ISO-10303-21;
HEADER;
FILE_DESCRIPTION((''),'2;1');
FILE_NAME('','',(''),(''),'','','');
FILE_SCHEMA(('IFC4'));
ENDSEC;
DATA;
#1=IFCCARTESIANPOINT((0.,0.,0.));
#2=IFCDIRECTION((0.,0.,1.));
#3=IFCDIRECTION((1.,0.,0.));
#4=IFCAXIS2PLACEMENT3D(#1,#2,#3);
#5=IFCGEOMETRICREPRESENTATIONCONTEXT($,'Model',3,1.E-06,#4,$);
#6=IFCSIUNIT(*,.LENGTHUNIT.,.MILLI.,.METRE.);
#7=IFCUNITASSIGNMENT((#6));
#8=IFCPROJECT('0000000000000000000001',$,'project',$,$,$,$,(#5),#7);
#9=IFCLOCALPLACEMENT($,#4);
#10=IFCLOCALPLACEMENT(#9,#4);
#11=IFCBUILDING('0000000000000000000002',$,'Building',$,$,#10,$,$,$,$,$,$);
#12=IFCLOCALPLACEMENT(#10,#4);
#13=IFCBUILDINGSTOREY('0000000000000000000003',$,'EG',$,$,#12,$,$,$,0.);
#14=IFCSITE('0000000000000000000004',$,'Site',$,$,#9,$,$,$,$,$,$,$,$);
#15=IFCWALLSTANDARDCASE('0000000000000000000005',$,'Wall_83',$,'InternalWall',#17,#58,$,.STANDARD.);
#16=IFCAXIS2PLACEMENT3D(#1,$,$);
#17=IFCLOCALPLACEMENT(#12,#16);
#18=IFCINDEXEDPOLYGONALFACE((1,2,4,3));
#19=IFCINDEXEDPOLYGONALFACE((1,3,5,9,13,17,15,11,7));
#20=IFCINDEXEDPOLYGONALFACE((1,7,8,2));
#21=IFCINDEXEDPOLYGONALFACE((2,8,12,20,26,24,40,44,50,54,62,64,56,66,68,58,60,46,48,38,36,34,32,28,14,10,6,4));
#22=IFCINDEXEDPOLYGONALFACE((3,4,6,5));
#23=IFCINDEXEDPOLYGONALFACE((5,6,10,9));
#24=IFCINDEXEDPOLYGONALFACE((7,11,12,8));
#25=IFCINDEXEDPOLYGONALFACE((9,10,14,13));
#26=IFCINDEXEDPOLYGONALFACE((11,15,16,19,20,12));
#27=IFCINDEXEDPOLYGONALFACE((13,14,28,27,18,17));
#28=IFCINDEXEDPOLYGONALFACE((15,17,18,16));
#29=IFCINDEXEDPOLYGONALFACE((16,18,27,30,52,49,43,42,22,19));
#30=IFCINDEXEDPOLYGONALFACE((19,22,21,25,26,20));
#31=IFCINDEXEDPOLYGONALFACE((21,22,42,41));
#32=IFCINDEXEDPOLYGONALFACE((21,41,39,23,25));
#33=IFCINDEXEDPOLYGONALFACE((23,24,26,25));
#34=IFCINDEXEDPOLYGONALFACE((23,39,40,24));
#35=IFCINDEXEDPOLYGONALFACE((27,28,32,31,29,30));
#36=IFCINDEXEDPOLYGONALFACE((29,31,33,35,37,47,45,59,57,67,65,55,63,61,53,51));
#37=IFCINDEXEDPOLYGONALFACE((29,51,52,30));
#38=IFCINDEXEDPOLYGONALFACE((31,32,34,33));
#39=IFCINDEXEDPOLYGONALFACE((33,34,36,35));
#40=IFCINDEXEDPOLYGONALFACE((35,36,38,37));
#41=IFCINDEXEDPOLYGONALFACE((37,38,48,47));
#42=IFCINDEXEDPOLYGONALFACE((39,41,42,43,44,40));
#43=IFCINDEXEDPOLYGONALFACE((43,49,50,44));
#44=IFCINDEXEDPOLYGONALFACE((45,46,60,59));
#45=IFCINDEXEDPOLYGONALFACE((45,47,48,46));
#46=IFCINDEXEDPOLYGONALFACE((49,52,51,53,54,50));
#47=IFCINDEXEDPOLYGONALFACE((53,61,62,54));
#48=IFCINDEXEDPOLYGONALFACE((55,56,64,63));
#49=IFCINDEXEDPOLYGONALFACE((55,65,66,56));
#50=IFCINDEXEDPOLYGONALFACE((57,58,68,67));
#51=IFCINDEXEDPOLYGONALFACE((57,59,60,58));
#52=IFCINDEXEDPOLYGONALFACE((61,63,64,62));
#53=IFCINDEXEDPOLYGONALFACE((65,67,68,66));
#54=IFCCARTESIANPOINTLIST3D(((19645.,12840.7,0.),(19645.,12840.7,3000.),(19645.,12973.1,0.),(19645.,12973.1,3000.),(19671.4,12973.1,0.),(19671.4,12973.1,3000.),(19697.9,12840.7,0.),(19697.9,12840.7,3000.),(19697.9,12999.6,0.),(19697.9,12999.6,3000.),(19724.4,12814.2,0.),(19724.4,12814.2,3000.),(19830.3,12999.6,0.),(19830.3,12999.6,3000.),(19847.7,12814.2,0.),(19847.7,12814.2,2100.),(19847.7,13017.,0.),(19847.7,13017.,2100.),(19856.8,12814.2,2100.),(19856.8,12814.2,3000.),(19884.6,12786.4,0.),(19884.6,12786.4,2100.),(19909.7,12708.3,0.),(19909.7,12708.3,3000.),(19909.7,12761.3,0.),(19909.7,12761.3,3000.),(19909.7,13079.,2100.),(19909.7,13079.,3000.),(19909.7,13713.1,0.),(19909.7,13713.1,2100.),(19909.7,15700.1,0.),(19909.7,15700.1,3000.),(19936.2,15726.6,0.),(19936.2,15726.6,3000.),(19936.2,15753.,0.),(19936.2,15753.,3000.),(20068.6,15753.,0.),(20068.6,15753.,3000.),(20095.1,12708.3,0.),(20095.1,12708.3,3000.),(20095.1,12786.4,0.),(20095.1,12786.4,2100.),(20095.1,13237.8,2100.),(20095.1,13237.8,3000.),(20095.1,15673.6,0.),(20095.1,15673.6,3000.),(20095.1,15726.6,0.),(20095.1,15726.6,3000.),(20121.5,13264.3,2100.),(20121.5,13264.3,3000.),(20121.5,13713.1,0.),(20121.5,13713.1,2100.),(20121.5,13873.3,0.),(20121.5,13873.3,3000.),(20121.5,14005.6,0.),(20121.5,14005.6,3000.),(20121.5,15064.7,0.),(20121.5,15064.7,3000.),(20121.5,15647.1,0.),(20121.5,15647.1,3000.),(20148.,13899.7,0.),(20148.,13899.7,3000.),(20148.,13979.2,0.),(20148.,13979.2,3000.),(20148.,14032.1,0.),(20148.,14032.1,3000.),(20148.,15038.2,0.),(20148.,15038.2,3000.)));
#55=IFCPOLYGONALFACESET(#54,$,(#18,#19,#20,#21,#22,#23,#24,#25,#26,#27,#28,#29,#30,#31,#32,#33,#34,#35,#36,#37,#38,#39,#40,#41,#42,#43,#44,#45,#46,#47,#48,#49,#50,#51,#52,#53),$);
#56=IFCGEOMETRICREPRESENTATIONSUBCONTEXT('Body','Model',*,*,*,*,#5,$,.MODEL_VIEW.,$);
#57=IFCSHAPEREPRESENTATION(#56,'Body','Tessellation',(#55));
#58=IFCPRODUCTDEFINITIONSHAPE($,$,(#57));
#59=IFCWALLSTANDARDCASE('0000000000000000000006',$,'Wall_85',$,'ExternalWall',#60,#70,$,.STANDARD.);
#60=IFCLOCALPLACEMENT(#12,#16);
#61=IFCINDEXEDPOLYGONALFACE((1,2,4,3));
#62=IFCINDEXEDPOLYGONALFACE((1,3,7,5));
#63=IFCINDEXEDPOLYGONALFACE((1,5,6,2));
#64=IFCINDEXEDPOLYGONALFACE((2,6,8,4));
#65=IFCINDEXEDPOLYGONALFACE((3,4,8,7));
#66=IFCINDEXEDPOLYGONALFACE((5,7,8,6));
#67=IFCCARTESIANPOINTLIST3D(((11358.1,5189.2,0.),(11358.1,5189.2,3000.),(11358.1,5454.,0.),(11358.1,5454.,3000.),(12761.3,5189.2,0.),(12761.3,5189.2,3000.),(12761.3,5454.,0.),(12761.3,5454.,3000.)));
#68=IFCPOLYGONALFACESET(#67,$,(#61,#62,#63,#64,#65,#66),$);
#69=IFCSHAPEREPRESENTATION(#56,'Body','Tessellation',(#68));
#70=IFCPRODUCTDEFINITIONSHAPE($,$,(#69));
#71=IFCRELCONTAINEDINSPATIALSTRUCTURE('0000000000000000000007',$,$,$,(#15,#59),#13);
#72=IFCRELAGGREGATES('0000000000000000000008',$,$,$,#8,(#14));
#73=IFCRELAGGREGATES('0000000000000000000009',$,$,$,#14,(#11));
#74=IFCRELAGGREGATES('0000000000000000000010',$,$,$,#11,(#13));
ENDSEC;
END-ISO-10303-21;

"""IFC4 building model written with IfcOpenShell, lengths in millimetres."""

from ifc_helpers import new_model, si_unit, frame, origin_with_axes, place, context, subcontext, project, spatial, polyline, rectangle, outline, extrude, element, save


model = new_model("IFC4")

# Units and contexts
model_context = context("Model", 3, precision=1e-06, world=origin_with_axes())
body_context = subcontext(model_context, "Body", "Model", "MODEL_VIEW")
ifc_project = project(units=[si_unit("LENGTHUNIT", "METRE", prefix="MILLI")], contexts=[model_context])

# Site, building, storey
site_placement = place(None, origin_with_axes())
site = spatial("IfcSite", under=ifc_project, at=site_placement, Name="Site")
building_placement = place(site_placement, origin_with_axes())
building = spatial("IfcBuilding", under=site, at=building_placement, Name="Building")
storey_placement = place(building_placement, origin_with_axes())
storey = spatial("IfcBuildingStorey", under=building, at=storey_placement, Name="EG", Elevation=0.0)

# Wall, opening
wall_1_placement = place(storey_placement, origin_with_axes())
wall_1 = element("IfcWallStandardCase", 1, at=wall_1_placement, inside=storey, Name="Wall_83", ObjectType="InternalWall", PredefinedType="STANDARD", context=body_context, shape_type="SweptSolid", body=[
    extrude(outline(polyline([(19909.7, 12708.3, 0.0), (19909.7, 12761.3, 0.0), (19856.8, 12814.2, 0.0), (19724.4, 12814.2, 0.0), (19697.9, 12840.7, 0.0), (19645.0, 12840.7, 0.0), (19645.0, 12973.1, 0.0), (19671.4, 12973.1, 0.0), (19697.9, 12999.6, 0.0), (19830.3, 12999.6, 0.0), (19909.7, 13079.0, 0.0), (19909.7, 15700.1, 0.0), (19936.2, 15726.6, 0.0), (19936.2, 15753.0, 0.0), (20068.6, 15753.0, 0.0), (20095.1, 15726.6, 0.0), (20095.1, 15673.6, 0.0), (20121.5, 15647.1, 0.0), (20121.5, 15064.7, 0.0), (20148.0, 15038.2, 0.0), (20148.0, 14032.1, 0.0), (20121.5, 14005.6, 0.0), (20148.0, 13979.2, 0.0), (20148.0, 13899.7, 0.0), (20121.5, 13873.3, 0.0), (20121.5, 13264.3, 0.0), (20095.1, 13237.8, 0.0), (20095.1, 12708.3, 0.0), (19909.7, 12708.3, 0.0)])), origin_with_axes(), (0.0, 0.0, 1.0), 3000.0),
])
opening_1_placement = place(wall_1_placement, origin_with_axes())
element("IfcOpeningElement", 2, at=opening_1_placement, inside=storey, cuts=wall_1, context=body_context, shape_type="SweptSolid", body=[
    extrude(rectangle(XDim=926.6, YDim=300.0), frame((19997.7, 13249.8, 0.0), z_axis=(0.0, 0.0, 1.0), x_axis=(0.0, 1.0, 0.0)), (0.0, 0.0, 1.0), 2100.0),
])

# Wall
for number, where, z_axis, x_axis, name in (
    (3, (0.0, 0.0, 0.0), (0.0, 0.0, 1.0), (1.0, 0.0, 0.0), "Wall_85"),
):
    element("IfcWallStandardCase", number, at=place(storey_placement, frame(where, z_axis=z_axis, x_axis=x_axis)), inside=storey, Name=name, ObjectType="ExternalWall", PredefinedType="STANDARD", context=body_context, shape_type="SweptSolid", body=[
        extrude(outline(polyline([(11358.1, 5189.2, 0.0), (11358.1, 5454.0, 0.0), (12761.3, 5454.0, 0.0), (12761.3, 5189.2, 0.0), (11358.1, 5189.2, 0.0)])), origin_with_axes(), (0.0, 0.0, 1.0), 3000.0),
    ])

save(model, "model.ifc")
